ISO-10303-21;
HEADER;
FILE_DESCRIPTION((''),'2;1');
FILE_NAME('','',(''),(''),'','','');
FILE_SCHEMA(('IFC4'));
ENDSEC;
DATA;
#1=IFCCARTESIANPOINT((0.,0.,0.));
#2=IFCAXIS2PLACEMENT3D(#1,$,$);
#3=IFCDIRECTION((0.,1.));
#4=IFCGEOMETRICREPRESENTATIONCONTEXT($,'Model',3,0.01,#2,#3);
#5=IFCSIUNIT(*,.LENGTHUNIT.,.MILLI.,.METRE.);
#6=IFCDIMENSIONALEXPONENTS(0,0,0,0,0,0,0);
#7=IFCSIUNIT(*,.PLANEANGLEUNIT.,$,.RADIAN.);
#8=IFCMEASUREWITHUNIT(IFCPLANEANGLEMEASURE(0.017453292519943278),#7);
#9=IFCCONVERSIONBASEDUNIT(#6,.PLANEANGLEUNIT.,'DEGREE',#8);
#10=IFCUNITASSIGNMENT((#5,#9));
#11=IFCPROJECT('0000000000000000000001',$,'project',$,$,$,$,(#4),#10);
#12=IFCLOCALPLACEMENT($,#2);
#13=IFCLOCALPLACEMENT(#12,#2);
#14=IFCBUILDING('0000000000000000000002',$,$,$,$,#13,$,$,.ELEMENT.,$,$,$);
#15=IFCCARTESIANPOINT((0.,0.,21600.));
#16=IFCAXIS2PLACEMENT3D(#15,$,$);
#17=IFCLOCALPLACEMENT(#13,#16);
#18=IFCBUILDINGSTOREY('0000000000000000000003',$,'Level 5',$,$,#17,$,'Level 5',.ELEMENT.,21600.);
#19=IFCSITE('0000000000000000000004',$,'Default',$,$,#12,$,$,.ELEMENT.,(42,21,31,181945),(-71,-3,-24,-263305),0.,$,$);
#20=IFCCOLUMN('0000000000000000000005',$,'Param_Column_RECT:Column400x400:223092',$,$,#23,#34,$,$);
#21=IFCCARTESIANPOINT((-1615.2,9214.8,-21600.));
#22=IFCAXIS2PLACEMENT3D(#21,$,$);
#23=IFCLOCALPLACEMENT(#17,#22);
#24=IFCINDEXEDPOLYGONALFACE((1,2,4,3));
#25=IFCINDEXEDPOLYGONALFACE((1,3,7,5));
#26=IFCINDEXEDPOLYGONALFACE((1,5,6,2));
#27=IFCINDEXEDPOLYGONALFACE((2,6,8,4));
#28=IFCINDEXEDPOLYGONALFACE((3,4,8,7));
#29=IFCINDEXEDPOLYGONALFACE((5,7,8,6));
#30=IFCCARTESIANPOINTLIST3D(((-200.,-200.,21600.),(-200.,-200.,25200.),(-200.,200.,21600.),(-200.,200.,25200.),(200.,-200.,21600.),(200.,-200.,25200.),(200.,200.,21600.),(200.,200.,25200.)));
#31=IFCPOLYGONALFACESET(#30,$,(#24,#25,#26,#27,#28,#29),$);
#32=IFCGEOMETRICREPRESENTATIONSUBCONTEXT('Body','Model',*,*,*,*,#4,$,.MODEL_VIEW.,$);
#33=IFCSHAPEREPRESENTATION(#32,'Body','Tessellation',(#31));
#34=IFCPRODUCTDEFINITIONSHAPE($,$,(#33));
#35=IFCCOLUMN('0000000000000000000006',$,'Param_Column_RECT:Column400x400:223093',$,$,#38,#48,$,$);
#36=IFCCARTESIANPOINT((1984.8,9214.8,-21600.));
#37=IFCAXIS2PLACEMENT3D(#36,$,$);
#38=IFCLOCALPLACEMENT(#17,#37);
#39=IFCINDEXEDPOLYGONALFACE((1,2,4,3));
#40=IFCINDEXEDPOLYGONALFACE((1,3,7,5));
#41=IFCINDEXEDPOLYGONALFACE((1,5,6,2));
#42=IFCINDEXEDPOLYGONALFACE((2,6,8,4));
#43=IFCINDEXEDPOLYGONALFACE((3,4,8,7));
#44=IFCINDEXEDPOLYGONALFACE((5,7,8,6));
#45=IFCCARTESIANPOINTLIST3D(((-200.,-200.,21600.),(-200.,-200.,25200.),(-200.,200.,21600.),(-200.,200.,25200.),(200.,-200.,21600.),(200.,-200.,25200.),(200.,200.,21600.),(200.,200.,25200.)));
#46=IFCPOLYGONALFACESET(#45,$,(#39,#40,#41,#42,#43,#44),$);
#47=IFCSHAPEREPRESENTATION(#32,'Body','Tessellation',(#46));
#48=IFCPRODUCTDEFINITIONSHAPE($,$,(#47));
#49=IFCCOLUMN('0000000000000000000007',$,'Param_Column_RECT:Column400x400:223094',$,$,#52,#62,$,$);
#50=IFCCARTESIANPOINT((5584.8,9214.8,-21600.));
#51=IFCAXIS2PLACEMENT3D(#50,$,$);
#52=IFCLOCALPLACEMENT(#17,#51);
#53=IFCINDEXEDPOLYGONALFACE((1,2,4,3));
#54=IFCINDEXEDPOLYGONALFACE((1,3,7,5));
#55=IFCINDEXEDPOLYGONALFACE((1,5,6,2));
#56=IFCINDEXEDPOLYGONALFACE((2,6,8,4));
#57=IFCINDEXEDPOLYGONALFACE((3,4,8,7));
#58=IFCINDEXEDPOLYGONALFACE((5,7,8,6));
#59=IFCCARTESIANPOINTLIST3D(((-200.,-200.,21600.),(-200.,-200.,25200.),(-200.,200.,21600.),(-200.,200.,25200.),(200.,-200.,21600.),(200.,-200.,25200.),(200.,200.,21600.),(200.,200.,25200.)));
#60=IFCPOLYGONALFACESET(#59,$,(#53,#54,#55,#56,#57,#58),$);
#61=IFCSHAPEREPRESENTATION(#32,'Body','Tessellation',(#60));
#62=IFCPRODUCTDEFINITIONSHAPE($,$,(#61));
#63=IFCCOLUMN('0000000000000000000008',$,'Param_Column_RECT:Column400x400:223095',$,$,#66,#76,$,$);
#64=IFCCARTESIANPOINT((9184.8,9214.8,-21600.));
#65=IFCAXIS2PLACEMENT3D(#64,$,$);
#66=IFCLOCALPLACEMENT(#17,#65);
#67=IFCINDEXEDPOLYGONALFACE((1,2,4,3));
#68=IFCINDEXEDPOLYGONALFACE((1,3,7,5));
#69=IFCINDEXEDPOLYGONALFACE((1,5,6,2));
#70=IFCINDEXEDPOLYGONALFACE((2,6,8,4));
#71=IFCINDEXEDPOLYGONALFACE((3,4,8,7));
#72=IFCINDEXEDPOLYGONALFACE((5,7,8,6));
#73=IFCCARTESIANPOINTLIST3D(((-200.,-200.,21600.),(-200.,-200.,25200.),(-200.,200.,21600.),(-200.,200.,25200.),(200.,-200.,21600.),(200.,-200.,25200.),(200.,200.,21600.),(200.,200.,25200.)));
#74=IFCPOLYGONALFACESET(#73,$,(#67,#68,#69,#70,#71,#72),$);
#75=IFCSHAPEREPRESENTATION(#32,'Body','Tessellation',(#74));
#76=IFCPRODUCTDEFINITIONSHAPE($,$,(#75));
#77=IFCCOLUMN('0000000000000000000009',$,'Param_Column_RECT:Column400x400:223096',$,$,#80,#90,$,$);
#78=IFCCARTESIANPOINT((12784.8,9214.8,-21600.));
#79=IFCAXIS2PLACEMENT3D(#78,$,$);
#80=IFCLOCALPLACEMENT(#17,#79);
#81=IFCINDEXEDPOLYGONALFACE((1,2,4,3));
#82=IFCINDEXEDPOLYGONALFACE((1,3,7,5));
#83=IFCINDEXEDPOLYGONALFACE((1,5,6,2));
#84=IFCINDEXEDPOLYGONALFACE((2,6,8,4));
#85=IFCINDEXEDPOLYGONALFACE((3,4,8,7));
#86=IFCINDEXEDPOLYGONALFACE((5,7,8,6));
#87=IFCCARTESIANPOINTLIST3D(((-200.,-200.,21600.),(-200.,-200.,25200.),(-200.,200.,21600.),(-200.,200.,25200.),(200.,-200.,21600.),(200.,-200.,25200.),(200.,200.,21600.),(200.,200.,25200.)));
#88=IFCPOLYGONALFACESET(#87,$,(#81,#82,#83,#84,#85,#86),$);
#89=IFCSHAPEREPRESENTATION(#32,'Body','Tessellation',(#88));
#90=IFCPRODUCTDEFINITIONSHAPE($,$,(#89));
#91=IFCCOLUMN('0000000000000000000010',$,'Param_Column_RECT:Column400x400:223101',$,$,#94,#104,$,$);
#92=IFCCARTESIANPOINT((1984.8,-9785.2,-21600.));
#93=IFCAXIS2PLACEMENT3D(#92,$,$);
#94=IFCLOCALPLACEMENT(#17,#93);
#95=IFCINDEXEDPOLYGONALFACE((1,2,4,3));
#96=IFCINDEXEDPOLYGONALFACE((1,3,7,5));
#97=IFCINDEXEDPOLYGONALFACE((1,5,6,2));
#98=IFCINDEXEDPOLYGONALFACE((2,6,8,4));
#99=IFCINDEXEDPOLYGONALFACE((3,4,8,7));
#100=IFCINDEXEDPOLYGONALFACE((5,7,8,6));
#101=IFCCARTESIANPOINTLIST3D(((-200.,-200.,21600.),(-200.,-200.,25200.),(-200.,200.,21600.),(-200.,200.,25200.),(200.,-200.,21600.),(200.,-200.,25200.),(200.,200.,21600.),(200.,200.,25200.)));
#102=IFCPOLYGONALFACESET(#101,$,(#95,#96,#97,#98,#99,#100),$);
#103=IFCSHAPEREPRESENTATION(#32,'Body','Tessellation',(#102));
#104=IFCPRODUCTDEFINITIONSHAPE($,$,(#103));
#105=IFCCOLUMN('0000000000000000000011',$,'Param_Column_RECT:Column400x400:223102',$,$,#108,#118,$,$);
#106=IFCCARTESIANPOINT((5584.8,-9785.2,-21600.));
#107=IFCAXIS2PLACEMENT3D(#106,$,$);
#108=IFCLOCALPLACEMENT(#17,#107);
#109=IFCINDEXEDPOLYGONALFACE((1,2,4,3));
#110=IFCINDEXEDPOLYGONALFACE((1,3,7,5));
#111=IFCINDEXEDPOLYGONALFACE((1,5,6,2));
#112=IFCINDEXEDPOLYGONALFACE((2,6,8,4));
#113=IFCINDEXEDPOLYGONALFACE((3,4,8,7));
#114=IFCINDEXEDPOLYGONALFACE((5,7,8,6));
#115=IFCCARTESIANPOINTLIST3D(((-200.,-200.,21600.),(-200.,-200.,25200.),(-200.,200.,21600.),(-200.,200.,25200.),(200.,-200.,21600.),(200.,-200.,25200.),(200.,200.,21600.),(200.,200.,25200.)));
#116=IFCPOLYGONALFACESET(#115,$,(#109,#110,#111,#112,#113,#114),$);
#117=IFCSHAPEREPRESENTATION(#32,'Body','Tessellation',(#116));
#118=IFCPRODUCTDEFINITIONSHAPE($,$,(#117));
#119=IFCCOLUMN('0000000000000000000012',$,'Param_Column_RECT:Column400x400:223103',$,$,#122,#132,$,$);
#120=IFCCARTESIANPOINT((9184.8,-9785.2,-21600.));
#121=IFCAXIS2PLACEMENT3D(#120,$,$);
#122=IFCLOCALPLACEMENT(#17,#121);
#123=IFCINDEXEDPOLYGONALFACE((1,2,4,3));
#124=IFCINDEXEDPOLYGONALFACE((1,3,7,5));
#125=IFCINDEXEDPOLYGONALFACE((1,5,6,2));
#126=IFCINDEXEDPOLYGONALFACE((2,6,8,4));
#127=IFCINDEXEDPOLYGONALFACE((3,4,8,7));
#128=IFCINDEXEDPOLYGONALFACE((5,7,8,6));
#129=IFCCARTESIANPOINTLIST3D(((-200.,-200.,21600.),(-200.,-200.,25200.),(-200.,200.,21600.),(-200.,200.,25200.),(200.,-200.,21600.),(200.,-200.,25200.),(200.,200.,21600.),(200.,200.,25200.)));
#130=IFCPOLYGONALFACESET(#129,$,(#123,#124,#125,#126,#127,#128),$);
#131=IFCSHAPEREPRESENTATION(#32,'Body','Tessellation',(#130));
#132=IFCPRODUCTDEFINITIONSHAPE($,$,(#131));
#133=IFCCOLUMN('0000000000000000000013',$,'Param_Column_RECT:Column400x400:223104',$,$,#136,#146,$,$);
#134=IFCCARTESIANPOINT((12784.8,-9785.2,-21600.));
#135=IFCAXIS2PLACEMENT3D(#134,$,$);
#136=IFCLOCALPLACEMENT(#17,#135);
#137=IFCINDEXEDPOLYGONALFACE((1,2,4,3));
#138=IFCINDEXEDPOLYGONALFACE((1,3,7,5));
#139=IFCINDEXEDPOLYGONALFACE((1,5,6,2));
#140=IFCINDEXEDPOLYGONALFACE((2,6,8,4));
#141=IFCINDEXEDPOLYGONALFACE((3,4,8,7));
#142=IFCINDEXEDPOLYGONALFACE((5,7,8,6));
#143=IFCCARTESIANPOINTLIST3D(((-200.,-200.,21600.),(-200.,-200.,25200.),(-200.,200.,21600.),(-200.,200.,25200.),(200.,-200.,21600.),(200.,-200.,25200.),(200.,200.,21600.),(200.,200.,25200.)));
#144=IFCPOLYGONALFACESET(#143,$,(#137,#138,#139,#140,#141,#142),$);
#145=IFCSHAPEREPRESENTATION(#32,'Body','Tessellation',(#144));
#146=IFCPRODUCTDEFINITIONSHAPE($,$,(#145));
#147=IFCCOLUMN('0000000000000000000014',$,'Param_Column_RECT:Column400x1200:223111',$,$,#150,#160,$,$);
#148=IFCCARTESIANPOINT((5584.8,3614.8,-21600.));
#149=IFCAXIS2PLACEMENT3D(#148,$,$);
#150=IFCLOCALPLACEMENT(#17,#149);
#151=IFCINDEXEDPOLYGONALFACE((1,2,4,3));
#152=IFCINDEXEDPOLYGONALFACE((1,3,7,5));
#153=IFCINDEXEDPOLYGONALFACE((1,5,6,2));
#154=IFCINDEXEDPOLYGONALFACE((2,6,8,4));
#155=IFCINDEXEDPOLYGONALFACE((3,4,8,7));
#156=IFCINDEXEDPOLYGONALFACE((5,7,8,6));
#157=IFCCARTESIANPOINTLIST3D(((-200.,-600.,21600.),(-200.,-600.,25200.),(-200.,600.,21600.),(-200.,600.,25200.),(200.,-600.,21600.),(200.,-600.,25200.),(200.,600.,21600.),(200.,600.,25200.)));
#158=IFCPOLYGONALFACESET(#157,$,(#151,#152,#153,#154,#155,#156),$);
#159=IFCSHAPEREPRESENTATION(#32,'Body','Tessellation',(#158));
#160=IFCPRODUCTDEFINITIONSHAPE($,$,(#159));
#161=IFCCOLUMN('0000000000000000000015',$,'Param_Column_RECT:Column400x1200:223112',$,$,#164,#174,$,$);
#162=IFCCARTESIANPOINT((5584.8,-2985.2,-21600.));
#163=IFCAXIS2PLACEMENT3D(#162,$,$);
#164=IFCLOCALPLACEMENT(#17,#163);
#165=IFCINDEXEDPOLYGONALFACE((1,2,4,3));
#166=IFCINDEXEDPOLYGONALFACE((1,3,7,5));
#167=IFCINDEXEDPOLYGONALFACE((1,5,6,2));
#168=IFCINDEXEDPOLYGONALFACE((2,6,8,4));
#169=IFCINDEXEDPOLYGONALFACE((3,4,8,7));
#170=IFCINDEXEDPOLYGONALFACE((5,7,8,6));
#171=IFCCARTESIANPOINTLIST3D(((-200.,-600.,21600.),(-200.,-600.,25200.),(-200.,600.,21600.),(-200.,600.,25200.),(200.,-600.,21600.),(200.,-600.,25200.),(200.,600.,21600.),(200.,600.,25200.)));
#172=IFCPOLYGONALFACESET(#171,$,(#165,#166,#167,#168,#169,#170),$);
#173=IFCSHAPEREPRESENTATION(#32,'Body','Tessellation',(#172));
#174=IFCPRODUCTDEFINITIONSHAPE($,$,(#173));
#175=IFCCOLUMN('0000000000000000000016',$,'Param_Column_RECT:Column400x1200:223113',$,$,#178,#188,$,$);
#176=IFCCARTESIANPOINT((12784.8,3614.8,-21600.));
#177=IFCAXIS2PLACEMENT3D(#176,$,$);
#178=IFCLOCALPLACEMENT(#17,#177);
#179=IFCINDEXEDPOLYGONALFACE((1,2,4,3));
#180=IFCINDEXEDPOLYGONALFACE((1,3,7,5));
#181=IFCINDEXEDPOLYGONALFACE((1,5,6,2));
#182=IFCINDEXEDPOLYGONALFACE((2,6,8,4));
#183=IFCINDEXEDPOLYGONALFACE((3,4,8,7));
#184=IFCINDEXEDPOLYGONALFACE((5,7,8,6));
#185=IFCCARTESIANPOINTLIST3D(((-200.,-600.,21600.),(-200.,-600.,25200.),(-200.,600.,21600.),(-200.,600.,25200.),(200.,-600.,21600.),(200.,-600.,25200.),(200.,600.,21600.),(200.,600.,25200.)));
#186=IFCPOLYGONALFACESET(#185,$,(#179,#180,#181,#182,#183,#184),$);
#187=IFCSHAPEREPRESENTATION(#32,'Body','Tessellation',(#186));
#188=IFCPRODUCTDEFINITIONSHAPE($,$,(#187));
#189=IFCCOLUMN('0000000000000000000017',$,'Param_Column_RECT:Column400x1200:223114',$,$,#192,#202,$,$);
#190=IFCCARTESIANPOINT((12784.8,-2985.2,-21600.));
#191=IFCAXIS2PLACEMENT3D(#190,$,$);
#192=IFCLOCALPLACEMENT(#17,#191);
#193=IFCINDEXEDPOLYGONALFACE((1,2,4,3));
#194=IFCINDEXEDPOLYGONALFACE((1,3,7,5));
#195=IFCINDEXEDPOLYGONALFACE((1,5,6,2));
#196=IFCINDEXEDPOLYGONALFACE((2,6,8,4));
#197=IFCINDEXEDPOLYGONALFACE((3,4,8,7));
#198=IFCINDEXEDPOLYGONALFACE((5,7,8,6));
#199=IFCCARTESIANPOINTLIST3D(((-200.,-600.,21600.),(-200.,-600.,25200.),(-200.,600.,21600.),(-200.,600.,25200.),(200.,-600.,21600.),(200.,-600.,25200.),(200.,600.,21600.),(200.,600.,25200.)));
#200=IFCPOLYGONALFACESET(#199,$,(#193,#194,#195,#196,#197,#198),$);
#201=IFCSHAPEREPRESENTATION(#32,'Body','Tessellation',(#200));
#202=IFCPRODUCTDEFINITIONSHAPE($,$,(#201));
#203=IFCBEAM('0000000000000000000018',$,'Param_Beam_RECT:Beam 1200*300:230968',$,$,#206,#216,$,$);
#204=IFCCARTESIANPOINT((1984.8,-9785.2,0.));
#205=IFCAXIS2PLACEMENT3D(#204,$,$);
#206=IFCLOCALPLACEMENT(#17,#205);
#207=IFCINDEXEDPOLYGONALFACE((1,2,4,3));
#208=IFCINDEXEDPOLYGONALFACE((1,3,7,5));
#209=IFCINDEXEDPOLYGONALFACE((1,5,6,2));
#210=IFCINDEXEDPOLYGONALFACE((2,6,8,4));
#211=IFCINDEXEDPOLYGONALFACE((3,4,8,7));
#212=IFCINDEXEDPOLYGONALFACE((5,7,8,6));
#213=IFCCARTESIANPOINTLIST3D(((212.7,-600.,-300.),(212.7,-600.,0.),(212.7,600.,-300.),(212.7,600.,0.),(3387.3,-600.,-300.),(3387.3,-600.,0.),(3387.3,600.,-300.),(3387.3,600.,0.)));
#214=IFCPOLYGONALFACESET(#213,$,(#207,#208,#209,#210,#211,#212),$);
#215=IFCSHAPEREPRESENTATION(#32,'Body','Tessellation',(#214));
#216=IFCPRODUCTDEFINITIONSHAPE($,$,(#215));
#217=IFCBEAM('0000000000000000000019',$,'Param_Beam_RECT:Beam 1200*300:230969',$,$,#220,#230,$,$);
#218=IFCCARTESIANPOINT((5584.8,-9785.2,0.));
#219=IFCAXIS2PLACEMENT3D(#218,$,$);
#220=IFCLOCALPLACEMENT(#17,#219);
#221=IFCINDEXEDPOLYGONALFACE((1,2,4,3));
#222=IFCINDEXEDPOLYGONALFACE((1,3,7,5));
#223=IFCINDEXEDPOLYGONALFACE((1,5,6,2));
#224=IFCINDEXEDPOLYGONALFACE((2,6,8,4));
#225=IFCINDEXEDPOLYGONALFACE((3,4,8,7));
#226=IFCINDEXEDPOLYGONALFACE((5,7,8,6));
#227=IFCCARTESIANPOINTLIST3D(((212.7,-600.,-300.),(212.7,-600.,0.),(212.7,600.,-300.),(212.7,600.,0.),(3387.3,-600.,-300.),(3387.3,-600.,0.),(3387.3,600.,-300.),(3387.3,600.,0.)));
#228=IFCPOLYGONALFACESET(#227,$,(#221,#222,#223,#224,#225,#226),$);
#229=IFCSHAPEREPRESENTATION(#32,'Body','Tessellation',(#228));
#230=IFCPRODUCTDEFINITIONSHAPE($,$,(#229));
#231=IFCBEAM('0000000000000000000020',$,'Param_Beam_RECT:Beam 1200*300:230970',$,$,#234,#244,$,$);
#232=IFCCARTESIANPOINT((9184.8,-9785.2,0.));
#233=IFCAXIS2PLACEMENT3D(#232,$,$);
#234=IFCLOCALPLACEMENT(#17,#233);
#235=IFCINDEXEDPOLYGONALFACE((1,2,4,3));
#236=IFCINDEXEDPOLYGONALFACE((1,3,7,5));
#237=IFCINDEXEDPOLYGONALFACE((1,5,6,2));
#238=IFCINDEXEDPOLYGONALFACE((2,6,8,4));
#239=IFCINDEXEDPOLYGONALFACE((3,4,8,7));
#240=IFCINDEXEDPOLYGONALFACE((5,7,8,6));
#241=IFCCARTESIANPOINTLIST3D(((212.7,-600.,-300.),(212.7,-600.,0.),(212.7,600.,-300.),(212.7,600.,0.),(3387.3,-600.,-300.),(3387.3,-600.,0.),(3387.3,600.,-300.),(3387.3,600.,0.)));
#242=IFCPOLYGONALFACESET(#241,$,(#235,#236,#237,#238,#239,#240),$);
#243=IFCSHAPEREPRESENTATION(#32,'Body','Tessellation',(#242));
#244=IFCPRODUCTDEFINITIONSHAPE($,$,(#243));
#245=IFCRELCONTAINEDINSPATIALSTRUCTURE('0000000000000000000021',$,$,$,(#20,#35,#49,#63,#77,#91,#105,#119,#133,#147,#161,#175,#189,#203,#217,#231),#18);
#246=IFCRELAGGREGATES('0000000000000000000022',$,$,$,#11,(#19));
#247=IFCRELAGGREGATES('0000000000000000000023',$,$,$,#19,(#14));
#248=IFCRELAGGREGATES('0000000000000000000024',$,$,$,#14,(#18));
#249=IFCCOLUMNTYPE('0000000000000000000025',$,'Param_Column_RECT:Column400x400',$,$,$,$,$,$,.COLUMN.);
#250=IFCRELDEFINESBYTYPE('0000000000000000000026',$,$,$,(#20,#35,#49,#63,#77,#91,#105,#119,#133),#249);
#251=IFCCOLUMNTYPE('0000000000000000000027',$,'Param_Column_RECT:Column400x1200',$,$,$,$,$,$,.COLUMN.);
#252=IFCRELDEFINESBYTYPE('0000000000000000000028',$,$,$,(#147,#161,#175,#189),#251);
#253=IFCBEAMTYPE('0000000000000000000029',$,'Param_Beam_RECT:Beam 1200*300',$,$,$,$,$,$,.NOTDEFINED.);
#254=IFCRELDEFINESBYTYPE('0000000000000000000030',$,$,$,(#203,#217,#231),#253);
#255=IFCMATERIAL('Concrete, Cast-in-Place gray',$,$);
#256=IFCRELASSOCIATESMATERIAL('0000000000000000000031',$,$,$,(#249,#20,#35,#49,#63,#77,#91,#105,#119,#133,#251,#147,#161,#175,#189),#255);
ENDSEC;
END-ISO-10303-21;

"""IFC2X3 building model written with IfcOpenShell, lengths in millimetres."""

from ifc_helpers import new_model, entity, si_unit, converted_unit, direction, frame, frame_2d, origin, origin_2d_with_axis, place, context, subcontext, project, spatial, rectangle, extrude, source, transform, mapped, material, type_object, type_shapes, element, save


model = new_model("IFC2X3")

# Units and contexts
model_context = context("Model", 3, precision=0.01, world=origin(), true_north=direction((0.0, 1.0)))
body_context = subcontext(model_context, "Body", "Model", "MODEL_VIEW")
ifc_project = project(units=[si_unit("LENGTHUNIT", "METRE", prefix="MILLI"), converted_unit("PLANEANGLEUNIT", "DEGREE", entity("IfcPlaneAngleMeasure", 0.017453292519943278), si_unit("PLANEANGLEUNIT", "RADIAN"), dimensions=[0, 0, 0, 0, 0, 0, 0])], contexts=[model_context])

# Site, building, storey
site_placement = place(None, origin())
site = spatial("IfcSite", under=ifc_project, at=site_placement, Name="Default", CompositionType="ELEMENT", RefLatitude=(42, 21, 31, 181945), RefLongitude=(-71, -3, -24, -263305), RefElevation=0.0)
building_placement = place(site_placement, origin())
building = spatial("IfcBuilding", under=site, at=building_placement, CompositionType="ELEMENT")
storey_placement = place(building_placement, frame((0.0, 0.0, 21600.0)))
storey = spatial("IfcBuildingStorey", under=building, at=storey_placement, Name="Level 5", LongName="Level 5", CompositionType="ELEMENT", Elevation=21600.0)

# Columns
ifc_material_1 = material(Name="Concrete, Cast-in-Place gray")
column_type_1 = type_object("IfcColumnType", Name="Param_Column_RECT:Column400x400", PredefinedType="COLUMN", material=ifc_material_1)
shared_shape_1 = source(origin(), body_context, "Body", "SweptSolid", [
    extrude(rectangle(XDim=400.0, YDim=400.0, at=origin_2d_with_axis()), frame((0.0, 0.0, 21600.0), z_axis=(0.0, 0.0, 1.0), x_axis=(-1.0, 0.0, 0.0)), (0.0, 0.0, 1.0), 3600.0),
])
type_shapes(column_type_1, [shared_shape_1])
for number, where, name in (
    (1, (-1615.2, 9214.8, -21600.0), "Param_Column_RECT:Column400x400:223092"),
    (2, (1984.8, 9214.8, -21600.0), "Param_Column_RECT:Column400x400:223093"),
    (3, (5584.8, 9214.8, -21600.0), "Param_Column_RECT:Column400x400:223094"),
    (4, (9184.8, 9214.8, -21600.0), "Param_Column_RECT:Column400x400:223095"),
    (5, (12784.8, 9214.8, -21600.0), "Param_Column_RECT:Column400x400:223096"),
    (6, (1984.8, -9785.2, -21600.0), "Param_Column_RECT:Column400x400:223101"),
    (7, (5584.8, -9785.2, -21600.0), "Param_Column_RECT:Column400x400:223102"),
    (8, (9184.8, -9785.2, -21600.0), "Param_Column_RECT:Column400x400:223103"),
    (9, (12784.8, -9785.2, -21600.0), "Param_Column_RECT:Column400x400:223104"),
):
    element("IfcColumn", number, at=place(storey_placement, frame(where)), inside=storey, type_object=column_type_1, material=ifc_material_1, Name=name, context=body_context, shape_type="MappedRepresentation", body=[
        mapped(shared_shape_1, transform((0.0, 0.0, 0.0), scale=1.0)),
    ])
column_type_2 = type_object("IfcColumnType", Name="Param_Column_RECT:Column400x1200", PredefinedType="COLUMN", material=ifc_material_1)
shared_shape_2 = source(origin(), body_context, "Body", "SweptSolid", [
    extrude(rectangle(XDim=400.0, YDim=1200.0, at=origin_2d_with_axis()), frame((0.0, 0.0, 21600.0), z_axis=(0.0, 0.0, 1.0), x_axis=(-1.0, 0.0, 0.0)), (0.0, 0.0, 1.0), 3600.0),
])
type_shapes(column_type_2, [shared_shape_2])
for number, where, name in (
    (10, (5584.8, 3614.8, -21600.0), "Param_Column_RECT:Column400x1200:223111"),
    (11, (5584.8, -2985.2, -21600.0), "Param_Column_RECT:Column400x1200:223112"),
    (12, (12784.8, 3614.8, -21600.0), "Param_Column_RECT:Column400x1200:223113"),
    (13, (12784.8, -2985.2, -21600.0), "Param_Column_RECT:Column400x1200:223114"),
):
    element("IfcColumn", number, at=place(storey_placement, frame(where)), inside=storey, type_object=column_type_2, material=ifc_material_1, Name=name, context=body_context, shape_type="MappedRepresentation", body=[
        mapped(shared_shape_2, transform((0.0, 0.0, 0.0), scale=1.0)),
    ])

# Beams
beam_type_1 = type_object("IfcBeamType", Name="Param_Beam_RECT:Beam 1200*300", PredefinedType="NOTDEFINED")
beam_1_placement = place(storey_placement, frame((1984.8, -9785.2, 0.0)))
element("IfcBeam", 14, at=beam_1_placement, inside=storey, type_object=beam_type_1, Name="Param_Beam_RECT:Beam 1200*300:230968", context=body_context, shape_type="SweptSolid", body=[
    extrude(rectangle(XDim=300.0, YDim=1200.0, at=origin_2d_with_axis()), frame((212.7, 0.0, -150.0), z_axis=(1.0, 0.0, 0.0), x_axis=(0.0, 0.0, -1.0)), (0.0, 0.0, 1.0), 3174.6),
])
for number, where, name in (
    (15, (5584.8, -9785.2, 0.0), "Param_Beam_RECT:Beam 1200*300:230969"),
    (16, (9184.8, -9785.2, 0.0), "Param_Beam_RECT:Beam 1200*300:230970"),
):
    element("IfcBeam", number, at=place(storey_placement, frame(where)), inside=storey, type_object=beam_type_1, Name=name, context=body_context, shape_type="SweptSolid", body=[
        extrude(rectangle(XDim=300.0, YDim=1200.0, at=frame_2d((0.0, 0.0), x_axis=(1.0, 0.0))), frame((212.7, 0.0, -150.0), z_axis=(1.0, 0.0, 0.0), x_axis=(0.0, 0.0, -1.0)), (0.0, 0.0, 1.0), 3174.6),
    ])

save(model, "model.ifc")
